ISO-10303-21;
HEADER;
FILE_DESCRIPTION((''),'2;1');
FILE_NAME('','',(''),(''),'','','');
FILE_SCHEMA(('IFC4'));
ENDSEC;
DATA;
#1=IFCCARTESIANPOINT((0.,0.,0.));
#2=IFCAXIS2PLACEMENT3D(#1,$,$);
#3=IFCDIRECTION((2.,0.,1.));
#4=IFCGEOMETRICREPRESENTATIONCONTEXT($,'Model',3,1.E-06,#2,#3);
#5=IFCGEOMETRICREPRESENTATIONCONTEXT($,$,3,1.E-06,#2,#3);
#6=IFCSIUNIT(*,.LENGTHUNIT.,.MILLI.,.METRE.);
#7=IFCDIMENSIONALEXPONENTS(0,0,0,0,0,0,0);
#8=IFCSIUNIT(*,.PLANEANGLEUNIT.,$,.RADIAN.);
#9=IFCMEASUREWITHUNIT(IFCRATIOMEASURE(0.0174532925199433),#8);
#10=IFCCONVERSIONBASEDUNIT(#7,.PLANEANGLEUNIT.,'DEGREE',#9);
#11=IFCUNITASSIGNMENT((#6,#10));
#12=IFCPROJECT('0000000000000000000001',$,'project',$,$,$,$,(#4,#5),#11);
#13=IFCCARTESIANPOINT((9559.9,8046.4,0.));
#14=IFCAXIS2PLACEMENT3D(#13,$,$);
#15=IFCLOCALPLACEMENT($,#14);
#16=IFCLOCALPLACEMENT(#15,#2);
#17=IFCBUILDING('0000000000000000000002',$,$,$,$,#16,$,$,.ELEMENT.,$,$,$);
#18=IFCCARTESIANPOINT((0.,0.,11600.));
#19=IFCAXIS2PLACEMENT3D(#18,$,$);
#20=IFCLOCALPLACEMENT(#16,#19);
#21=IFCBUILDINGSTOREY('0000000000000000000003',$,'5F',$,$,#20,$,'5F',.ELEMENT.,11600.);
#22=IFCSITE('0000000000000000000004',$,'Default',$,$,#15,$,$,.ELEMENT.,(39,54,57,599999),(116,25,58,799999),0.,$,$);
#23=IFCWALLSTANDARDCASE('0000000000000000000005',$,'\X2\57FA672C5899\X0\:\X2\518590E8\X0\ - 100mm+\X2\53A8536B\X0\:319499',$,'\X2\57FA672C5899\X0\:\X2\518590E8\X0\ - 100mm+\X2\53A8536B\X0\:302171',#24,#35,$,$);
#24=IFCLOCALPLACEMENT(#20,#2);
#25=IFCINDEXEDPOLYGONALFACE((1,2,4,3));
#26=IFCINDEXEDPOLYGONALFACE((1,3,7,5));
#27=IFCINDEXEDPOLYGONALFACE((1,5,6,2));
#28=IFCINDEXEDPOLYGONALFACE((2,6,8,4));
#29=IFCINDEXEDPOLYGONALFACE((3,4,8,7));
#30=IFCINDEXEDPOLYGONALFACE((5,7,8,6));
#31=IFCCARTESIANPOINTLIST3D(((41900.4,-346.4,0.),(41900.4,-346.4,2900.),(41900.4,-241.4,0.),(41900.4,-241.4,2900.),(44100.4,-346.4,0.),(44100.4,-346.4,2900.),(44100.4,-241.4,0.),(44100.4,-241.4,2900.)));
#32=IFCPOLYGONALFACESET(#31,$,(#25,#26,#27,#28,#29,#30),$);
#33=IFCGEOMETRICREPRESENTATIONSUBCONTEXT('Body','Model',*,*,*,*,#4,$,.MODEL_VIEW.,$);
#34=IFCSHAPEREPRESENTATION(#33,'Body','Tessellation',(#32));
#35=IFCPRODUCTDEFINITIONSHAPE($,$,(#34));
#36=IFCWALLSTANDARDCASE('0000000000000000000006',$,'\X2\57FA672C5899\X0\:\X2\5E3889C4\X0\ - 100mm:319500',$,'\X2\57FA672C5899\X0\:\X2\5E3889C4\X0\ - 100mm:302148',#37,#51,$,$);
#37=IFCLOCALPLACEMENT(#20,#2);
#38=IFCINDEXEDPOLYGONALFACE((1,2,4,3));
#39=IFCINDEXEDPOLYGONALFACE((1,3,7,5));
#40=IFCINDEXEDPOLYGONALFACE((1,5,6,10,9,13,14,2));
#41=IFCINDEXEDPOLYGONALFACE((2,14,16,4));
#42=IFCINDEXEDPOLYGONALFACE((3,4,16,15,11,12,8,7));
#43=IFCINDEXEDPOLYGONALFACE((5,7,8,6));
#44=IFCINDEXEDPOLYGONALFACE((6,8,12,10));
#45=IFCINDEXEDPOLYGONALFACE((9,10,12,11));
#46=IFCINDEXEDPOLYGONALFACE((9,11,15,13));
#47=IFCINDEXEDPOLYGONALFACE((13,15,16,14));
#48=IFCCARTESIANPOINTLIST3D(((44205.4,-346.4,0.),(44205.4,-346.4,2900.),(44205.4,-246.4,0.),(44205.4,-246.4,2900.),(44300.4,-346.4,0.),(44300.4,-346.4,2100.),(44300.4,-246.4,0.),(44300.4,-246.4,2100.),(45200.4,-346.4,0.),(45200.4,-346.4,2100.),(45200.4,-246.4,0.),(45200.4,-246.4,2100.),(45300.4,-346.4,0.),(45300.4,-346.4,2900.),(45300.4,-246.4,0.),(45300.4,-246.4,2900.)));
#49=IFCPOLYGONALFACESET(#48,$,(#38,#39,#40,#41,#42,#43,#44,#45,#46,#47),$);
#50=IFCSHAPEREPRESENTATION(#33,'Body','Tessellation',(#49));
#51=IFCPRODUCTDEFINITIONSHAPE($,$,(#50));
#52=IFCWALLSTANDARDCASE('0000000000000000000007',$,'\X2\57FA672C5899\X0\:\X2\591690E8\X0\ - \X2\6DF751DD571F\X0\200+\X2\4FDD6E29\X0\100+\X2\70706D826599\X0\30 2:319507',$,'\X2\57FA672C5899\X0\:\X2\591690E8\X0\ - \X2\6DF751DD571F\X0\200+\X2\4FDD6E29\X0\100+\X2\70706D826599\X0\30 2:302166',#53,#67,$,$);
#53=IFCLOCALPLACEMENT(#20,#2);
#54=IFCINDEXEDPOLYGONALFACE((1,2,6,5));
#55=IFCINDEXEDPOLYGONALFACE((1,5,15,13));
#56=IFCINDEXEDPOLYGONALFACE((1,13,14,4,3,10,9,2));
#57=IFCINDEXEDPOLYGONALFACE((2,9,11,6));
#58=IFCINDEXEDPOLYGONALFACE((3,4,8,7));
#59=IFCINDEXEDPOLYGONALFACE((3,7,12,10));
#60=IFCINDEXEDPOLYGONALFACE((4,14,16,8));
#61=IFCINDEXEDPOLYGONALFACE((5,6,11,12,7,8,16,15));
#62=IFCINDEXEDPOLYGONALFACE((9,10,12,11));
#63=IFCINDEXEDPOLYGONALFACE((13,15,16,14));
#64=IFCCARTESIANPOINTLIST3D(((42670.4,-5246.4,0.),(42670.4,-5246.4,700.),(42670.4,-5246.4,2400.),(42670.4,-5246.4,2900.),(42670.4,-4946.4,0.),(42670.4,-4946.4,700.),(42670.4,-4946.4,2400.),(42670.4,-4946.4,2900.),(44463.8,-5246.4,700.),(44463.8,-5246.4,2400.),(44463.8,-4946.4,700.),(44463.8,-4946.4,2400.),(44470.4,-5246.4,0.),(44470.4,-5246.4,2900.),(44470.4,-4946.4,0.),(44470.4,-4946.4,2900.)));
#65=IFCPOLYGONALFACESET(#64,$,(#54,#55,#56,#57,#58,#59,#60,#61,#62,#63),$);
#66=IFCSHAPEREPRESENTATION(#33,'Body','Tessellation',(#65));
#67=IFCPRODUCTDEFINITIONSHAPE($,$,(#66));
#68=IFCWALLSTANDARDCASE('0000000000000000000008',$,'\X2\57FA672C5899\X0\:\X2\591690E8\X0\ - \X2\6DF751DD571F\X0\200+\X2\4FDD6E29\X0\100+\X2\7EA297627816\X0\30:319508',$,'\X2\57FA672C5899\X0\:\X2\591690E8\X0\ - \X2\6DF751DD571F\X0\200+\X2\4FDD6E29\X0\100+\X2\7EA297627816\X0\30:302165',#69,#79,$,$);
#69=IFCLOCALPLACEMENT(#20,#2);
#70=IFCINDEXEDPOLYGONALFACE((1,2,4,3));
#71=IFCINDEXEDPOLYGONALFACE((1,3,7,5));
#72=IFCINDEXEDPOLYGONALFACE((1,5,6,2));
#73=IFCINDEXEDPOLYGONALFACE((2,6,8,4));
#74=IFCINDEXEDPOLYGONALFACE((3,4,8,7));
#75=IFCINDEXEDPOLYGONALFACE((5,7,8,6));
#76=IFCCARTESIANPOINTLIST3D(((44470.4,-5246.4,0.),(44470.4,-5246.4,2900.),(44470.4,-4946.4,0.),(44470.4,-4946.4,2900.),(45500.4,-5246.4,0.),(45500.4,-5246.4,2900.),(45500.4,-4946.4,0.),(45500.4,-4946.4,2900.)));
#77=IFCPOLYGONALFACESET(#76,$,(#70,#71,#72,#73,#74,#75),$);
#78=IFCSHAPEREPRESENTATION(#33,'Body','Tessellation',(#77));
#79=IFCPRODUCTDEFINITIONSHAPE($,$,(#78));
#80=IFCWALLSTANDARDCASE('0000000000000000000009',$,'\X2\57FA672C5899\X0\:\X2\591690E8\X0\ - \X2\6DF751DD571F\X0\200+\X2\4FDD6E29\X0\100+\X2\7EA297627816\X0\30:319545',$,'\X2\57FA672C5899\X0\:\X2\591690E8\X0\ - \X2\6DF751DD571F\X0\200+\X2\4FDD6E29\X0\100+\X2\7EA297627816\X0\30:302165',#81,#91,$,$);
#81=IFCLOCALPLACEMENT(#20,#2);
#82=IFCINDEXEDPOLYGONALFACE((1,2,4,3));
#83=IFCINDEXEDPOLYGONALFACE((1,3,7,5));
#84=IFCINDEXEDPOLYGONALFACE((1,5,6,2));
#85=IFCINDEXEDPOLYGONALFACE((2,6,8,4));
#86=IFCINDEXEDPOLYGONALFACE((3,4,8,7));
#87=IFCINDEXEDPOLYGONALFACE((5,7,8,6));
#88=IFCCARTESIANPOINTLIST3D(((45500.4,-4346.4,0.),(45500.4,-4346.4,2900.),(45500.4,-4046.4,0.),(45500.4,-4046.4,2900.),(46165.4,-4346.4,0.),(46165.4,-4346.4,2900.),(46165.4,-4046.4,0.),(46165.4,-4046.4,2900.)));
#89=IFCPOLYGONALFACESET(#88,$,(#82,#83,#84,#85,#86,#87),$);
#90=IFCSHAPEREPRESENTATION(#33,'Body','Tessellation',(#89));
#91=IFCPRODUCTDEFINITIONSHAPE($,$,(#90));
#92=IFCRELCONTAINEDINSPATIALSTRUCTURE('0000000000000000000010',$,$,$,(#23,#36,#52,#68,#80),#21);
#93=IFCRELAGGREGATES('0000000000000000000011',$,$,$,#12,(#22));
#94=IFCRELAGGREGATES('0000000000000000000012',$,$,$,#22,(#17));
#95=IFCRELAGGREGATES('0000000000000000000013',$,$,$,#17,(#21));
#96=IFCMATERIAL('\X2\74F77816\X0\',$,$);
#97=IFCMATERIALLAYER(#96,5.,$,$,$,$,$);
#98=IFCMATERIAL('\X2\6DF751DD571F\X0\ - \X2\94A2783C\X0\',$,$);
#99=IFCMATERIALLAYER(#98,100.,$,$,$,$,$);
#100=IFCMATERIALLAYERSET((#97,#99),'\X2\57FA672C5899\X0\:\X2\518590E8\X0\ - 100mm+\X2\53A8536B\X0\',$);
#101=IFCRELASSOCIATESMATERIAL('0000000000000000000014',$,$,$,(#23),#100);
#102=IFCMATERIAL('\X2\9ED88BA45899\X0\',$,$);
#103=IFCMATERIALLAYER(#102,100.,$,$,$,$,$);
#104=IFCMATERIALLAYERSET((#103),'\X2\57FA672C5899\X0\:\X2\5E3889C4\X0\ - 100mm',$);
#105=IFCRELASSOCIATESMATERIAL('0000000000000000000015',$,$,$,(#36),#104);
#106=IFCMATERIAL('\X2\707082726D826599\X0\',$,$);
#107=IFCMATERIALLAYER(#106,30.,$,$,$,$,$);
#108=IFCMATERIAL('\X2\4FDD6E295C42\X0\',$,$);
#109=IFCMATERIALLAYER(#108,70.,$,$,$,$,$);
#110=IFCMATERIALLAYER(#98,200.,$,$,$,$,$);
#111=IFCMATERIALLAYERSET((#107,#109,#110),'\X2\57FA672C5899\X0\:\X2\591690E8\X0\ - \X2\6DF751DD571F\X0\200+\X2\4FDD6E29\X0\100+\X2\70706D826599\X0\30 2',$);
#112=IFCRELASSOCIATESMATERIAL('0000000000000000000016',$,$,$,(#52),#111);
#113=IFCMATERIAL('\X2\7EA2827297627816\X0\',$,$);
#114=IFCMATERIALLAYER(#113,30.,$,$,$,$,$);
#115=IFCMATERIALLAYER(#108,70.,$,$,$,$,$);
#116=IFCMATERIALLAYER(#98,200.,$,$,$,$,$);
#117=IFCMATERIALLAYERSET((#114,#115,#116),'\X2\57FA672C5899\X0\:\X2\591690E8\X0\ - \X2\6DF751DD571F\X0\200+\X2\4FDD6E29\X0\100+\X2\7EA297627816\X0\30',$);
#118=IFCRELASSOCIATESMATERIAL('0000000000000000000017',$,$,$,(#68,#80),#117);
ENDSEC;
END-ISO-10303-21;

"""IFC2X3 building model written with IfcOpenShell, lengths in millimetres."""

from ifc_helpers import new_model, entity, si_unit, converted_unit, direction, frame, frame_2d, origin, place, context, subcontext, project, spatial, rectangle, extrude, material, layer, layer_set, layer_usage, element, save


model = new_model("IFC2X3")

# Units and contexts
model_context = context("Model", 3, precision=1e-06, world=origin(), true_north=direction((2.0, 0.0, 1.0)))
context_of_model = context(None, 3, precision=1e-06, world=origin(), true_north=direction((2.0, 0.0, 1.0)))
body_context = subcontext(model_context, "Body", "Model", "MODEL_VIEW")
ifc_project = project(units=[si_unit("LENGTHUNIT", "METRE", prefix="MILLI"), converted_unit("PLANEANGLEUNIT", "DEGREE", entity("IfcRatioMeasure", 0.0174532925199433), si_unit("PLANEANGLEUNIT", "RADIAN"), dimensions=[0, 0, 0, 0, 0, 0, 0])], contexts=[model_context, context_of_model])

# Site, building, storey
site_placement = place(None, frame((9559.9, 8046.4, 0.0)))
site = spatial("IfcSite", under=ifc_project, at=site_placement, Name="Default", CompositionType="ELEMENT", RefLatitude=(39, 54, 57, 599999), RefLongitude=(116, 25, 58, 799999), RefElevation=0.0)
building_placement = place(site_placement, origin())
building = spatial("IfcBuilding", under=site, at=building_placement, CompositionType="ELEMENT")
storey_placement = place(building_placement, frame((0.0, 0.0, 11600.0)))
storey = spatial("IfcBuildingStorey", under=building, at=storey_placement, Name="5F", LongName="5F", CompositionType="ELEMENT", Elevation=11600.0)

# Shared definitions
ifc_material_1 = material(Name="混凝土 - 钢砼")
ifc_material_2 = material(Name="红色面砖")
ifc_layer_1 = layer(ifc_material_2, 30.0)
ifc_material_3 = material(Name="保温层")
ifc_layer_2 = layer(ifc_material_3, 70.0)
ifc_layer_3 = layer(ifc_material_1, 200.0)
ifc_layer_set_1 = layer_set([ifc_layer_1, ifc_layer_2, ifc_layer_3], Name="基本墙:外部 - 混凝土200+保温100+红面砖30")

# Shared definitions
ifc_material_4 = material(Name="默认墙")
ifc_layer_4 = layer(ifc_material_4, 100.0)
ifc_layer_set_2 = layer_set([ifc_layer_4], Name="基本墙:常规 - 100mm")

# Shared definitions
ifc_material_5 = material(Name="瓷砖")
ifc_layer_5 = layer(ifc_material_5, 5.0)
ifc_layer_6 = layer(ifc_material_1, 100.0)
ifc_layer_set_3 = layer_set([ifc_layer_5, ifc_layer_6], Name="基本墙:内部 - 100mm+厨卫")

# Shared definitions
ifc_material_6 = material(Name="灰色涂料")
ifc_layer_7 = layer(ifc_material_6, 30.0)
ifc_layer_8 = layer(ifc_material_3, 70.0)
ifc_layer_9 = layer(ifc_material_1, 200.0)
ifc_layer_set_4 = layer_set([ifc_layer_7, ifc_layer_8, ifc_layer_9], Name="基本墙:外部 - 混凝土200+保温100+灰涂料30 2")

# Wall
ifc_layer_usage_1 = layer_usage(ifc_layer_set_3, "AXIS2", "NEGATIVE", 52.5)
wall_1_placement = place(storey_placement, frame((41900.4, -293.9, 0.0)))
element("IfcWallStandardCase", 1, at=wall_1_placement, inside=storey, material=ifc_layer_usage_1, Name="基本墙:内部 - 100mm+厨卫:319499", ObjectType="基本墙:内部 - 100mm+厨卫:302171", context=body_context, shape_type="SweptSolid", body=[
    extrude(rectangle(XDim=2200.0, YDim=105.0, at=frame_2d((1100.0, 0.0), x_axis=(-1.0, 0.0))), origin(), (0.0, 0.0, 1.0), 2900.0),
])

# Walls, openings
ifc_layer_usage_2 = layer_usage(ifc_layer_set_2, "AXIS2", "NEGATIVE", 50.0)
wall_2_placement = place(storey_placement, frame((44205.4, -296.4, 0.0)))
wall_2 = element("IfcWallStandardCase", 2, at=wall_2_placement, inside=storey, material=ifc_layer_usage_2, Name="基本墙:常规 - 100mm:319500", ObjectType="基本墙:常规 - 100mm:302148", context=body_context, shape_type="SweptSolid", body=[
    extrude(rectangle(XDim=1095.0, YDim=100.0, at=frame_2d((547.5, 0.0), x_axis=(-1.0, 0.0))), origin(), (0.0, 0.0, 1.0), 2900.0),
])
opening_1_placement = place(wall_2_placement, frame((995.0, 50.0, 0.0)))
element("IfcOpeningElement", 3, at=opening_1_placement, cuts=wall_2, ObjectType="Opening", context=body_context, shape_type="SweptSolid", body=[
    extrude(rectangle(XDim=2100.0, YDim=900.0, at=frame_2d((1050.0, 450.0), x_axis=(1.0, 0.0))), frame((0.0, 0.0, 0.0), z_axis=(0.0, -1.0, 0.0), x_axis=(0.0, 0.0, 1.0)), (0.0, 0.0, 1.0), 100.0),
])
ifc_layer_usage_3 = layer_usage(ifc_layer_set_4, "AXIS2", "POSITIVE", -150.0)
wall_3_placement = place(storey_placement, frame((42670.4, -5096.4, 0.0)))
wall_3 = element("IfcWallStandardCase", 4, at=wall_3_placement, inside=storey, material=ifc_layer_usage_3, Name="基本墙:外部 - 混凝土200+保温100+灰涂料30 2:319507", ObjectType="基本墙:外部 - 混凝土200+保温100+灰涂料30 2:302166", context=body_context, shape_type="SweptSolid", body=[
    extrude(rectangle(XDim=1800.0, YDim=300.0, at=frame_2d((900.0, 0.0), x_axis=(-1.0, 0.0))), origin(), (0.0, 0.0, 1.0), 2900.0),
])
opening_2_placement = place(wall_3_placement, frame((1793.4, 150.0, 700.0)))
element("IfcOpeningElement", 5, at=opening_2_placement, cuts=wall_3, ObjectType="Opening", context=body_context, shape_type="SweptSolid", body=[
    extrude(rectangle(XDim=1700.0, YDim=1800.0, at=frame_2d((850.0, 900.0), x_axis=(1.0, 0.0))), frame((0.0, 0.0, 0.0), z_axis=(0.0, -1.0, 0.0), x_axis=(0.0, 0.0, 1.0)), (0.0, 0.0, 1.0), 300.0),
])

# Walls
ifc_layer_usage_4 = layer_usage(ifc_layer_set_1, "AXIS2", "POSITIVE", -150.0)
wall_4_placement = place(storey_placement, frame((44470.4, -5096.4, 0.0)))
element("IfcWallStandardCase", 6, at=wall_4_placement, inside=storey, material=ifc_layer_usage_4, Name="基本墙:外部 - 混凝土200+保温100+红面砖30:319508", ObjectType="基本墙:外部 - 混凝土200+保温100+红面砖30:302165", context=body_context, shape_type="SweptSolid", body=[
    extrude(rectangle(XDim=1030.0, YDim=300.0, at=frame_2d((515.0, 0.0), x_axis=(-1.0, 0.0))), origin(), (0.0, 0.0, 1.0), 2900.0),
])
ifc_layer_usage_5 = layer_usage(ifc_layer_set_1, "AXIS2", "POSITIVE", -150.0)
wall_5_placement = place(storey_placement, frame((45500.4, -4196.4, 0.0)))
element("IfcWallStandardCase", 7, at=wall_5_placement, inside=storey, material=ifc_layer_usage_5, Name="基本墙:外部 - 混凝土200+保温100+红面砖30:319545", ObjectType="基本墙:外部 - 混凝土200+保温100+红面砖30:302165", context=body_context, shape_type="SweptSolid", body=[
    extrude(rectangle(XDim=665.0, YDim=300.0, at=frame_2d((332.5, 0.0), x_axis=(-1.0, 0.0))), origin(), (0.0, 0.0, 1.0), 2900.0),
])

save(model, "model.ifc")
